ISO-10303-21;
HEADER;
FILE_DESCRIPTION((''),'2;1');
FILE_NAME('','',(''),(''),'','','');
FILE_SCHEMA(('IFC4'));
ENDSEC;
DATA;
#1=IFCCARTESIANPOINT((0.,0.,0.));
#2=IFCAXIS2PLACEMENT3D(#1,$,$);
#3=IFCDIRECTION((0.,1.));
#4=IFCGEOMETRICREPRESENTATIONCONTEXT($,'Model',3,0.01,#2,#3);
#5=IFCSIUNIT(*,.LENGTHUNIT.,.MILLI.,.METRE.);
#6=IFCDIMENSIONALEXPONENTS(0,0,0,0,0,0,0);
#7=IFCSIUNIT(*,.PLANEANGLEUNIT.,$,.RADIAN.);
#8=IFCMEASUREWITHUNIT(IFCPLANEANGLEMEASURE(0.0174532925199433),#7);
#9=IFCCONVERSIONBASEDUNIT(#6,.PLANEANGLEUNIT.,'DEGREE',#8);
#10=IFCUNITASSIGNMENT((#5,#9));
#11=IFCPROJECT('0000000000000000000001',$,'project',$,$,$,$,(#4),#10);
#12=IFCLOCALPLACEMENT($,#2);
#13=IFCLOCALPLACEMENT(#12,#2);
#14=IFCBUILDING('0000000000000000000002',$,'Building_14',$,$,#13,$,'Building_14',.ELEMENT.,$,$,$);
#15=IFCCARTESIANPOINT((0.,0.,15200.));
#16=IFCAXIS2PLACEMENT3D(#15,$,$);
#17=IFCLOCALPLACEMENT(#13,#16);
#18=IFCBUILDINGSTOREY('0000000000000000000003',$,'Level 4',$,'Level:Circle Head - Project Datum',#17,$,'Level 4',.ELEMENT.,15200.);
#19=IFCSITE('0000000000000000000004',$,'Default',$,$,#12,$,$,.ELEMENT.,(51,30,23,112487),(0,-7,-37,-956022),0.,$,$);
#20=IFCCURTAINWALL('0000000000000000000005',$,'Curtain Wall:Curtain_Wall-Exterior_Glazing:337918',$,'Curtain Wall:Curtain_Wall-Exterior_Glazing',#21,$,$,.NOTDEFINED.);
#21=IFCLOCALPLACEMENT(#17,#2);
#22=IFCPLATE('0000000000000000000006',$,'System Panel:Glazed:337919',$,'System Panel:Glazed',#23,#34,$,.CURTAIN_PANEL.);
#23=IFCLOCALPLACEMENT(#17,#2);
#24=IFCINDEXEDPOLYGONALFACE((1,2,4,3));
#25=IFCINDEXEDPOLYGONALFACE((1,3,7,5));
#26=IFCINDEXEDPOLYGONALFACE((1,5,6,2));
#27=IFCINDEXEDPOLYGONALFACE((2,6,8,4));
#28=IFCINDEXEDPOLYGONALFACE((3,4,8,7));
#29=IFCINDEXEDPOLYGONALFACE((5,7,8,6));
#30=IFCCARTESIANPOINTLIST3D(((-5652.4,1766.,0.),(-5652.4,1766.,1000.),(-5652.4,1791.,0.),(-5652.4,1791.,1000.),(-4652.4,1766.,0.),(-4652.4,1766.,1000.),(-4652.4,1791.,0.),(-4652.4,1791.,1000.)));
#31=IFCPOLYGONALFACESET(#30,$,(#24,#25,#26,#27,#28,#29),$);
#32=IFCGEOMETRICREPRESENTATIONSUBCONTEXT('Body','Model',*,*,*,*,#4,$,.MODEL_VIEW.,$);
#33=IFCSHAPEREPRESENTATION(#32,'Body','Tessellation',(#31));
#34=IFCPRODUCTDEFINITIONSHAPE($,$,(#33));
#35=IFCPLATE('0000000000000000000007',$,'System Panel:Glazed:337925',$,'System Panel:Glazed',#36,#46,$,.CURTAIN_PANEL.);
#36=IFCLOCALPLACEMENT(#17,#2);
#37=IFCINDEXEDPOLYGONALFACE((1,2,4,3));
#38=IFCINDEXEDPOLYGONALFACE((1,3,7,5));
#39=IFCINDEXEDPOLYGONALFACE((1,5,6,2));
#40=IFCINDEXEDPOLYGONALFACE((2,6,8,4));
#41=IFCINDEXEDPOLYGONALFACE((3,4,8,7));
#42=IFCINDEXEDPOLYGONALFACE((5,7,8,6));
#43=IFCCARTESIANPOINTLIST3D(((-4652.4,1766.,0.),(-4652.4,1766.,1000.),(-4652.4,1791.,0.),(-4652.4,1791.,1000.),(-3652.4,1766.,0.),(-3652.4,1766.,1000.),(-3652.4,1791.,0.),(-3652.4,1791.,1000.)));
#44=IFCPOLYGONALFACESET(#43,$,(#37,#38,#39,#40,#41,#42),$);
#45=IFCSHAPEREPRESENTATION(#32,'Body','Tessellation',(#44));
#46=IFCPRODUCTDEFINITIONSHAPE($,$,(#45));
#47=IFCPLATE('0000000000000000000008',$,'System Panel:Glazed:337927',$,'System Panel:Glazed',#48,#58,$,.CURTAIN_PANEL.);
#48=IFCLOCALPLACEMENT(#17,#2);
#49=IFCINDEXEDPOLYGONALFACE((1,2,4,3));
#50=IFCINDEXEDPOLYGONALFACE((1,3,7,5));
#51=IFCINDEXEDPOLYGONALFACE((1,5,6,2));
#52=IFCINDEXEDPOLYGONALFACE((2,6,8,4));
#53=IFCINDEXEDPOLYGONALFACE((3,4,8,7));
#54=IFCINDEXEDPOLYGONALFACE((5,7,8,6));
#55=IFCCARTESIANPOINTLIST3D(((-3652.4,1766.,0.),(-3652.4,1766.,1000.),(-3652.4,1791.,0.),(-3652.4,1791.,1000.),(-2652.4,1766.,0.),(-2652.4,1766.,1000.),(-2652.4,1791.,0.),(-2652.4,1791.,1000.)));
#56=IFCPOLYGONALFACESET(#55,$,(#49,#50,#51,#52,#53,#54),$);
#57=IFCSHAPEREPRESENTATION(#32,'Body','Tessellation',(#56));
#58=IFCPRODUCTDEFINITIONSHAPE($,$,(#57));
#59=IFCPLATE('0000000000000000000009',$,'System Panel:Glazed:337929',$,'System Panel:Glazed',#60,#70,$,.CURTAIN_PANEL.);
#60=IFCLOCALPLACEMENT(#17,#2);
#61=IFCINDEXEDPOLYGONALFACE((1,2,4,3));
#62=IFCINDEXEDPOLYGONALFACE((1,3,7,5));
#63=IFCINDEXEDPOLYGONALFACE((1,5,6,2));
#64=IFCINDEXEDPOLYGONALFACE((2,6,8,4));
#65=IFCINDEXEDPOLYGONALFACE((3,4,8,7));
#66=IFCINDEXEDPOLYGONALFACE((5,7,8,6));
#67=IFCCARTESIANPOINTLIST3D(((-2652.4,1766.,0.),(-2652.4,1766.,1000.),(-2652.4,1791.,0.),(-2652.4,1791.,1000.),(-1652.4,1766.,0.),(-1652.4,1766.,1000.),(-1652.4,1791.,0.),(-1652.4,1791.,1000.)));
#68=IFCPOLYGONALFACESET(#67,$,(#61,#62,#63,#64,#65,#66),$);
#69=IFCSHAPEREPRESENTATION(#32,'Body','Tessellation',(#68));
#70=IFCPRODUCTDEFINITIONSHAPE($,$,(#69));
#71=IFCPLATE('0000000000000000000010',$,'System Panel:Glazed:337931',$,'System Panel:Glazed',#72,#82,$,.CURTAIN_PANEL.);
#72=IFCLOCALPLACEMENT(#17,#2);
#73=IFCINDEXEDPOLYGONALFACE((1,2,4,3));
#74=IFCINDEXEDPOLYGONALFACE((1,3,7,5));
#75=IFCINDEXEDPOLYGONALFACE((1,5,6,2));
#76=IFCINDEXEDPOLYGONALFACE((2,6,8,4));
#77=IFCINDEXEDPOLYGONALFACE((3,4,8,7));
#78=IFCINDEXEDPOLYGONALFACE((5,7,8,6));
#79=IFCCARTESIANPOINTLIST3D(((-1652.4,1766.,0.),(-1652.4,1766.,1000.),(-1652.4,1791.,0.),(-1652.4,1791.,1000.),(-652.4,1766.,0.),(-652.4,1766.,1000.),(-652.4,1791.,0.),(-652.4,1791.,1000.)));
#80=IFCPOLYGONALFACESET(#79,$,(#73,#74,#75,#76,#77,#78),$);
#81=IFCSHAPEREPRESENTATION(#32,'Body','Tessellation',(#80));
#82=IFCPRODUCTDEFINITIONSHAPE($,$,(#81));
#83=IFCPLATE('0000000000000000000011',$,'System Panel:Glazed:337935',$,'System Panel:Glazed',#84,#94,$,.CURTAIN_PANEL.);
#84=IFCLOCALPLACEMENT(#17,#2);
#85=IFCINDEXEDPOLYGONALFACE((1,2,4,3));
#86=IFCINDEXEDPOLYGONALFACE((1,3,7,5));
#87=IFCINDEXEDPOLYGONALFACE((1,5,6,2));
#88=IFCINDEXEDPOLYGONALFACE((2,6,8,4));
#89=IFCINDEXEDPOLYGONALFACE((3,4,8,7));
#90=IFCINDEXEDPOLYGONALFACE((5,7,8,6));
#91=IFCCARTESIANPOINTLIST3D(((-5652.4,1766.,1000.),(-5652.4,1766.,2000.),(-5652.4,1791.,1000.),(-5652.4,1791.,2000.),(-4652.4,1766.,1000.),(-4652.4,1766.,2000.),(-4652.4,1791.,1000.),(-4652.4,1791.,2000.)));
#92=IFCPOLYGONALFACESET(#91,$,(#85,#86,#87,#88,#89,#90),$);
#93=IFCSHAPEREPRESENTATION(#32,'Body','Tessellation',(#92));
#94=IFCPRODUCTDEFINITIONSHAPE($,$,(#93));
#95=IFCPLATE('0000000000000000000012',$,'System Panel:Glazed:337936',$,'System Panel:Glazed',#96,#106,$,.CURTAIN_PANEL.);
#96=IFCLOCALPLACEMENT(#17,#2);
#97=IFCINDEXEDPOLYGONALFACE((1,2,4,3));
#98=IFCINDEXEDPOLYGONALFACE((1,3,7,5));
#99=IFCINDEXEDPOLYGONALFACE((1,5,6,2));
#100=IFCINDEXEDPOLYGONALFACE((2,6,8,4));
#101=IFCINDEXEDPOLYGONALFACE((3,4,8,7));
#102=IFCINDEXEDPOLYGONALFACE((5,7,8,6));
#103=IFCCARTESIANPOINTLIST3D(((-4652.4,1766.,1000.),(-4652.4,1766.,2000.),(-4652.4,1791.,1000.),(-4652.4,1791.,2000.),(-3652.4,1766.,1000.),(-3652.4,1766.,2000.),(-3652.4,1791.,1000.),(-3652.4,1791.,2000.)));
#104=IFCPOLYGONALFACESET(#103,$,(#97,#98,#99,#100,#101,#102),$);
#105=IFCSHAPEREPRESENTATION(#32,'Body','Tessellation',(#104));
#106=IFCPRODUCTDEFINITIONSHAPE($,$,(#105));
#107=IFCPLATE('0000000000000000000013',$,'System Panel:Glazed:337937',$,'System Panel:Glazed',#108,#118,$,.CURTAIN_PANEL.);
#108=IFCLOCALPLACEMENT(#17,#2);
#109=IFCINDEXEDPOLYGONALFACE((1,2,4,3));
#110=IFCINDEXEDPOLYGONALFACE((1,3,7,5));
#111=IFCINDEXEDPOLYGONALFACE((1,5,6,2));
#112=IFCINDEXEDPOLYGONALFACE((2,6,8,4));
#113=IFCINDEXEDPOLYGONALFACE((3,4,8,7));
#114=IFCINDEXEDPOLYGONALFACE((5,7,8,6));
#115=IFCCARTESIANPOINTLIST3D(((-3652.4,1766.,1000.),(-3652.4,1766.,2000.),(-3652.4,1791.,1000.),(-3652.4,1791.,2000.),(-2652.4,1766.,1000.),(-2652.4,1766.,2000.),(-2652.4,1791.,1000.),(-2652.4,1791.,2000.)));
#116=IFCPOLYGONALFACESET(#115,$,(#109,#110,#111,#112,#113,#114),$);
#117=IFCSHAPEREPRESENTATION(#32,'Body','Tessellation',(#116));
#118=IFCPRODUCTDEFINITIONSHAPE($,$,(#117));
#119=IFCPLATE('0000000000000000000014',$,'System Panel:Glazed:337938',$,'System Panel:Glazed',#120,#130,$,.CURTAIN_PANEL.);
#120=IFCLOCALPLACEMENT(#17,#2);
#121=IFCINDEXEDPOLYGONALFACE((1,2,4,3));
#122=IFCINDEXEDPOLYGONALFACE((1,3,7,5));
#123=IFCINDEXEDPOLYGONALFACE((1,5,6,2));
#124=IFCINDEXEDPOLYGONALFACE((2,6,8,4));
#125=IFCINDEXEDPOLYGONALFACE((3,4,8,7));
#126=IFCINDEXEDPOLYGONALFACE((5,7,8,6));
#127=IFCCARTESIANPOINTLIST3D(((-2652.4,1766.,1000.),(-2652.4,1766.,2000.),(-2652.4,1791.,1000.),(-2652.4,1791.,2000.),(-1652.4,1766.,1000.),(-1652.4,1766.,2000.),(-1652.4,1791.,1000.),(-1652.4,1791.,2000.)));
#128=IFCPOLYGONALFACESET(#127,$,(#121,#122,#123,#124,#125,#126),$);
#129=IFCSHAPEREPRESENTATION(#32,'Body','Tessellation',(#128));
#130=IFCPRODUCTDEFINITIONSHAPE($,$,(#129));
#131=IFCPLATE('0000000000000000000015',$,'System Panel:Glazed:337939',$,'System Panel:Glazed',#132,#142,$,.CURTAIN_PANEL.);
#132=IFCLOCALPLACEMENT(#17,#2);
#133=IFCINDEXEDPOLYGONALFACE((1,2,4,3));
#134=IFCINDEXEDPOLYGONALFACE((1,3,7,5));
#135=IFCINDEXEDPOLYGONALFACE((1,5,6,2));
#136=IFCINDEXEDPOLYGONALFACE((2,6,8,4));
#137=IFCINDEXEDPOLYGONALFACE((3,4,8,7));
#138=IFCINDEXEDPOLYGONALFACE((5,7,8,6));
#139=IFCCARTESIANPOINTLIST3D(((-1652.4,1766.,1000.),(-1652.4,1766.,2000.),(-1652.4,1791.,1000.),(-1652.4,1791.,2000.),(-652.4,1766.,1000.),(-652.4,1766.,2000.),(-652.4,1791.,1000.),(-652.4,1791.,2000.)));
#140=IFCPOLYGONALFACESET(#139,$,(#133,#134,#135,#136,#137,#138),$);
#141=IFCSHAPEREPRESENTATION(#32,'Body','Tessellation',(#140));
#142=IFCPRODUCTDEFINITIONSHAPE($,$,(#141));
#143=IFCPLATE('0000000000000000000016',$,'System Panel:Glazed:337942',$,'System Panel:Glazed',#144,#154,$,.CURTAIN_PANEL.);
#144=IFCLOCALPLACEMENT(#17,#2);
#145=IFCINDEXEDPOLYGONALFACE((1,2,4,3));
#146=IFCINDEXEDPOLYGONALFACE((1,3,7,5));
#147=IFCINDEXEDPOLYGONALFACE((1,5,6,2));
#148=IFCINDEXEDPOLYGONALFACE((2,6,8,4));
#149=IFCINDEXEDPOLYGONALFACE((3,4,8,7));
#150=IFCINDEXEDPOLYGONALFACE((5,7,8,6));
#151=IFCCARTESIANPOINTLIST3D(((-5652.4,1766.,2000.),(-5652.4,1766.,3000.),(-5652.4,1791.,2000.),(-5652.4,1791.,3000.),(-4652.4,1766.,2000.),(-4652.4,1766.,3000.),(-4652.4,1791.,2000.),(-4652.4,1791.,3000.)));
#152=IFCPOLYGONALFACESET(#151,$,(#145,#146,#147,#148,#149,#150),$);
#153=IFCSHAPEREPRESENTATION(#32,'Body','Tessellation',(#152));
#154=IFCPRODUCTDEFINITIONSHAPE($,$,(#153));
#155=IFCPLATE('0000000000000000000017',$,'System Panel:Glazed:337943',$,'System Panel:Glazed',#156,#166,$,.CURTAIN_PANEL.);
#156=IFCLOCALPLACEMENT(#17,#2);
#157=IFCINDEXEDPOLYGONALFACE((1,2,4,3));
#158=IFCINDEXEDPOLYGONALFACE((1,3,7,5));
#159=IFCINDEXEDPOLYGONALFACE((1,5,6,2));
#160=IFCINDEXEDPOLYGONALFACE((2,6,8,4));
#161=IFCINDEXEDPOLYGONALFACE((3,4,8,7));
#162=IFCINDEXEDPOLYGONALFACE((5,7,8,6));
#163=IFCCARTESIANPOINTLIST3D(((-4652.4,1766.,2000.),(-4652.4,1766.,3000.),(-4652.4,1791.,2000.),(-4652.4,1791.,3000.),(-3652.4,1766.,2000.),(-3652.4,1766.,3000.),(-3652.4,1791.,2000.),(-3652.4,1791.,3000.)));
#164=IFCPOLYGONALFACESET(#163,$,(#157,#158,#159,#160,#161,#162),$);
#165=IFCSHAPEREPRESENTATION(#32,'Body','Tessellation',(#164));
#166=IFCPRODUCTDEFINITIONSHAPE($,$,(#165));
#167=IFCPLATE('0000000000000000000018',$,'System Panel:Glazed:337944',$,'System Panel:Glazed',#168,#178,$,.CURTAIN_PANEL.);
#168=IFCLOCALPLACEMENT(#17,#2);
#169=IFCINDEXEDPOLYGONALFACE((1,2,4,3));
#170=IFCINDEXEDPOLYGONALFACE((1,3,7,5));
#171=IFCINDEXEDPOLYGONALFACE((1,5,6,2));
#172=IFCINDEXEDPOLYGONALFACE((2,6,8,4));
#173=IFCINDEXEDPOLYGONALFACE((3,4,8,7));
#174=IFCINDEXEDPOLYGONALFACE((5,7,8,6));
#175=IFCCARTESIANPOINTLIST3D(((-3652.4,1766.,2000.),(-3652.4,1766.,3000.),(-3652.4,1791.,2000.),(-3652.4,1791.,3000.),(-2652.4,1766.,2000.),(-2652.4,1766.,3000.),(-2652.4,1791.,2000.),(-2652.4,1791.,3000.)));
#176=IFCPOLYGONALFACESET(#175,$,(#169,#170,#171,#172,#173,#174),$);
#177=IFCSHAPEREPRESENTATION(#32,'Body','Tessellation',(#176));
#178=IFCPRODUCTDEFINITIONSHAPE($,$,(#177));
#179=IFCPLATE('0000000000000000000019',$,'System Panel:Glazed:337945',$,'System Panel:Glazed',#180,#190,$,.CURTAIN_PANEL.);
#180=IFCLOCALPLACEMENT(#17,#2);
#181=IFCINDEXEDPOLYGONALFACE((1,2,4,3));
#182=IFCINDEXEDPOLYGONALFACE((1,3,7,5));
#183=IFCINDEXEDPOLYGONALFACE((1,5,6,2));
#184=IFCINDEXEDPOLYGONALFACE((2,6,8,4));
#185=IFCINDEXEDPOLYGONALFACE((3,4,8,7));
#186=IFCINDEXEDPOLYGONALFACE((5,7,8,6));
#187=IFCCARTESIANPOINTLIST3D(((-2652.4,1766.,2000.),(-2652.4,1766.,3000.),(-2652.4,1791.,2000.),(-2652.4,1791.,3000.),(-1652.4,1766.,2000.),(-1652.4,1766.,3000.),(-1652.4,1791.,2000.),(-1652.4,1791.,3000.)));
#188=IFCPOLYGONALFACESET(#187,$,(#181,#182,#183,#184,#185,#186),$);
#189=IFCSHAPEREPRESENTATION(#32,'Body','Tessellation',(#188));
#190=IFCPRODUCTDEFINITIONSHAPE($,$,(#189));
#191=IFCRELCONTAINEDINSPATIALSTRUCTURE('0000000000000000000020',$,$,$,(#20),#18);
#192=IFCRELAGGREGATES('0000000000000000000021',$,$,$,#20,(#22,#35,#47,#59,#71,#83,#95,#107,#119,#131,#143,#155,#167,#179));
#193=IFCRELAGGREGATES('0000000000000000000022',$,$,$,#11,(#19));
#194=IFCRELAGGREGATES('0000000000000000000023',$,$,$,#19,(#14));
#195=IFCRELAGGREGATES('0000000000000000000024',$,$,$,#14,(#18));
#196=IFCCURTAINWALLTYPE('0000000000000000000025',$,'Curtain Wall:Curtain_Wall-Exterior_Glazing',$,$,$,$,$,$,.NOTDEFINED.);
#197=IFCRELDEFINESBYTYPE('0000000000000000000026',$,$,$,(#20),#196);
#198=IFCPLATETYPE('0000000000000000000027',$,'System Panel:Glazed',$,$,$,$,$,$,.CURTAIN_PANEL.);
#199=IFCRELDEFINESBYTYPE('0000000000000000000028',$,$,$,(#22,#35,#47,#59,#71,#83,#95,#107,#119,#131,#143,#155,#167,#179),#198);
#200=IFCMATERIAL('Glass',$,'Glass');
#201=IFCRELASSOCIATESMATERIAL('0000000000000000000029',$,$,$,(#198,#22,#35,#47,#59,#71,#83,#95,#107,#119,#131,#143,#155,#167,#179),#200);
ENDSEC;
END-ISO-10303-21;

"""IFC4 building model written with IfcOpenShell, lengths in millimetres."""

from ifc_helpers import new_model, entity, si_unit, converted_unit, direction, frame, origin, place, context, subcontext, project, spatial, indexed_curve, outline, extrude, source, transform, mapped, material, type_object, type_shapes, element, aggregate, save


model = new_model("IFC4")

# Units and contexts
model_context = context("Model", 3, precision=0.01, world=origin(), true_north=direction((0.0, 1.0)))
body_context = subcontext(model_context, "Body", "Model", "MODEL_VIEW")
ifc_project = project(units=[si_unit("LENGTHUNIT", "METRE", prefix="MILLI"), converted_unit("PLANEANGLEUNIT", "DEGREE", entity("IfcPlaneAngleMeasure", 0.0174532925199433), si_unit("PLANEANGLEUNIT", "RADIAN"), dimensions=[0, 0, 0, 0, 0, 0, 0])], contexts=[model_context])

# Site, building, storey
site_placement = place(None, origin())
site = spatial("IfcSite", under=ifc_project, at=site_placement, Name="Default", CompositionType="ELEMENT", RefLatitude=(51, 30, 23, 112487), RefLongitude=(0, -7, -37, -956022), RefElevation=0.0)
building_placement = place(site_placement, origin())
building = spatial("IfcBuilding", under=site, at=building_placement, Name="Building_14", LongName="Building_14", CompositionType="ELEMENT")
storey_placement = place(building_placement, frame((0.0, 0.0, 15200.0)))
storey = spatial("IfcBuildingStorey", under=building, at=storey_placement, Name="Level 4", ObjectType="Level:Circle Head - Project Datum", LongName="Level 4", CompositionType="ELEMENT", Elevation=15200.0)

# Curtain wall, plates
curtain_wall_type = type_object("IfcCurtainWallType", Name="Curtain Wall:Curtain_Wall-Exterior_Glazing", PredefinedType="NOTDEFINED")
curtain_wall_placement = place(storey_placement, frame((0.0, 0.0, -15200.0)))
curtain_wall = element("IfcCurtainWall", 1, at=curtain_wall_placement, inside=storey, type_object=curtain_wall_type, Name="Curtain Wall:Curtain_Wall-Exterior_Glazing:337918", ObjectType="Curtain Wall:Curtain_Wall-Exterior_Glazing", PredefinedType="NOTDEFINED")
ifc_material_1 = material(Name="Glass", Category="Glass")
plate_type_1 = type_object("IfcPlateType", Name="System Panel:Glazed", PredefinedType="CURTAIN_PANEL", material=ifc_material_1)
shared_shape_1 = source(origin(), body_context, "Body", "SweptSolid", [
    extrude(outline(indexed_curve([(-12.5, -500.0), (12.5, -500.0), (12.5, 500.0), (-12.5, 500.0), (-12.5, -500.0)], self_intersect=False)), frame((0.0, -37.0, 0.0), z_axis=(0.0, 0.0, 1.0), x_axis=(0.0, 1.0, 0.0)), (0.0, 0.0, 1.0), 1000.0),
])
type_shapes(plate_type_1, [shared_shape_1])
plate_1_placement = place(curtain_wall_placement, frame((-5152.4, 1815.5, 15200.0)))
plate_1 = element("IfcPlate", 2, at=plate_1_placement, type_object=plate_type_1, material=ifc_material_1, Name="System Panel:Glazed:337919", ObjectType="System Panel:Glazed", PredefinedType="CURTAIN_PANEL", context=body_context, shape_type="MappedRepresentation", body=[
    mapped(shared_shape_1, transform((0.0, 0.0, 0.0), scale=1.0)),
])
plate_2_placement = place(curtain_wall_placement, frame((-4152.4, 1815.5, 15200.0)))
plate_2 = element("IfcPlate", 3, at=plate_2_placement, type_object=plate_type_1, material=ifc_material_1, Name="System Panel:Glazed:337925", ObjectType="System Panel:Glazed", PredefinedType="CURTAIN_PANEL", context=body_context, shape_type="MappedRepresentation", body=[
    mapped(shared_shape_1, transform((0.0, 0.0, 0.0), scale=1.0)),
])
plate_3_placement = place(curtain_wall_placement, frame((-3152.4, 1815.5, 15200.0)))
plate_3 = element("IfcPlate", 4, at=plate_3_placement, type_object=plate_type_1, material=ifc_material_1, Name="System Panel:Glazed:337927", ObjectType="System Panel:Glazed", PredefinedType="CURTAIN_PANEL", context=body_context, shape_type="MappedRepresentation", body=[
    mapped(shared_shape_1, transform((0.0, 0.0, 0.0), scale=1.0)),
])
plate_4_placement = place(curtain_wall_placement, frame((-2152.4, 1815.5, 15200.0)))
plate_4 = element("IfcPlate", 5, at=plate_4_placement, type_object=plate_type_1, material=ifc_material_1, Name="System Panel:Glazed:337929", ObjectType="System Panel:Glazed", PredefinedType="CURTAIN_PANEL", context=body_context, shape_type="MappedRepresentation", body=[
    mapped(shared_shape_1, transform((0.0, 0.0, 0.0), scale=1.0)),
])
plate_5_placement = place(curtain_wall_placement, frame((-1152.4, 1815.5, 15200.0)))
plate_5 = element("IfcPlate", 6, at=plate_5_placement, type_object=plate_type_1, material=ifc_material_1, Name="System Panel:Glazed:337931", ObjectType="System Panel:Glazed", PredefinedType="CURTAIN_PANEL", context=body_context, shape_type="MappedRepresentation", body=[
    mapped(shared_shape_1, transform((0.0, 0.0, 0.0), scale=1.0)),
])
plate_6_placement = place(curtain_wall_placement, frame((-5152.4, 1815.5, 16200.0)))
plate_6 = element("IfcPlate", 7, at=plate_6_placement, type_object=plate_type_1, material=ifc_material_1, Name="System Panel:Glazed:337935", ObjectType="System Panel:Glazed", PredefinedType="CURTAIN_PANEL", context=body_context, shape_type="MappedRepresentation", body=[
    mapped(shared_shape_1, transform((0.0, 0.0, 0.0), scale=1.0)),
])
plate_7_placement = place(curtain_wall_placement, frame((-4152.4, 1815.5, 16200.0)))
plate_7 = element("IfcPlate", 8, at=plate_7_placement, type_object=plate_type_1, material=ifc_material_1, Name="System Panel:Glazed:337936", ObjectType="System Panel:Glazed", PredefinedType="CURTAIN_PANEL", context=body_context, shape_type="MappedRepresentation", body=[
    mapped(shared_shape_1, transform((0.0, 0.0, 0.0), scale=1.0)),
])
plate_8_placement = place(curtain_wall_placement, frame((-3152.4, 1815.5, 16200.0)))
plate_8 = element("IfcPlate", 9, at=plate_8_placement, type_object=plate_type_1, material=ifc_material_1, Name="System Panel:Glazed:337937", ObjectType="System Panel:Glazed", PredefinedType="CURTAIN_PANEL", context=body_context, shape_type="MappedRepresentation", body=[
    mapped(shared_shape_1, transform((0.0, 0.0, 0.0), scale=1.0)),
])
plate_9_placement = place(curtain_wall_placement, frame((-2152.4, 1815.5, 16200.0)))
plate_9 = element("IfcPlate", 10, at=plate_9_placement, type_object=plate_type_1, material=ifc_material_1, Name="System Panel:Glazed:337938", ObjectType="System Panel:Glazed", PredefinedType="CURTAIN_PANEL", context=body_context, shape_type="MappedRepresentation", body=[
    mapped(shared_shape_1, transform((0.0, 0.0, 0.0), scale=1.0)),
])
plate_10_placement = place(curtain_wall_placement, frame((-1152.4, 1815.5, 16200.0)))
plate_10 = element("IfcPlate", 11, at=plate_10_placement, type_object=plate_type_1, material=ifc_material_1, Name="System Panel:Glazed:337939", ObjectType="System Panel:Glazed", PredefinedType="CURTAIN_PANEL", context=body_context, shape_type="MappedRepresentation", body=[
    mapped(shared_shape_1, transform((0.0, 0.0, 0.0), scale=1.0)),
])
plate_11_placement = place(curtain_wall_placement, frame((-5152.4, 1815.5, 17200.0)))
plate_11 = element("IfcPlate", 12, at=plate_11_placement, type_object=plate_type_1, material=ifc_material_1, Name="System Panel:Glazed:337942", ObjectType="System Panel:Glazed", PredefinedType="CURTAIN_PANEL", context=body_context, shape_type="MappedRepresentation", body=[
    mapped(shared_shape_1, transform((0.0, 0.0, 0.0), scale=1.0)),
])
plate_12_placement = place(curtain_wall_placement, frame((-4152.4, 1815.5, 17200.0)))
plate_12 = element("IfcPlate", 13, at=plate_12_placement, type_object=plate_type_1, material=ifc_material_1, Name="System Panel:Glazed:337943", ObjectType="System Panel:Glazed", PredefinedType="CURTAIN_PANEL", context=body_context, shape_type="MappedRepresentation", body=[
    mapped(shared_shape_1, transform((0.0, 0.0, 0.0), scale=1.0)),
])
plate_13_placement = place(curtain_wall_placement, frame((-3152.4, 1815.5, 17200.0)))
plate_13 = element("IfcPlate", 14, at=plate_13_placement, type_object=plate_type_1, material=ifc_material_1, Name="System Panel:Glazed:337944", ObjectType="System Panel:Glazed", PredefinedType="CURTAIN_PANEL", context=body_context, shape_type="MappedRepresentation", body=[
    mapped(shared_shape_1, transform((0.0, 0.0, 0.0), scale=1.0)),
])
plate_14_placement = place(curtain_wall_placement, frame((-2152.4, 1815.5, 17200.0)))
plate_14 = element("IfcPlate", 15, at=plate_14_placement, type_object=plate_type_1, material=ifc_material_1, Name="System Panel:Glazed:337945", ObjectType="System Panel:Glazed", PredefinedType="CURTAIN_PANEL", context=body_context, shape_type="MappedRepresentation", body=[
    mapped(shared_shape_1, transform((0.0, 0.0, 0.0), scale=1.0)),
])
aggregate(curtain_wall, [plate_1, plate_2, plate_3, plate_4, plate_5, plate_6, plate_7, plate_8, plate_9, plate_10, plate_11, plate_12, plate_13, plate_14])

save(model, "model.ifc")
